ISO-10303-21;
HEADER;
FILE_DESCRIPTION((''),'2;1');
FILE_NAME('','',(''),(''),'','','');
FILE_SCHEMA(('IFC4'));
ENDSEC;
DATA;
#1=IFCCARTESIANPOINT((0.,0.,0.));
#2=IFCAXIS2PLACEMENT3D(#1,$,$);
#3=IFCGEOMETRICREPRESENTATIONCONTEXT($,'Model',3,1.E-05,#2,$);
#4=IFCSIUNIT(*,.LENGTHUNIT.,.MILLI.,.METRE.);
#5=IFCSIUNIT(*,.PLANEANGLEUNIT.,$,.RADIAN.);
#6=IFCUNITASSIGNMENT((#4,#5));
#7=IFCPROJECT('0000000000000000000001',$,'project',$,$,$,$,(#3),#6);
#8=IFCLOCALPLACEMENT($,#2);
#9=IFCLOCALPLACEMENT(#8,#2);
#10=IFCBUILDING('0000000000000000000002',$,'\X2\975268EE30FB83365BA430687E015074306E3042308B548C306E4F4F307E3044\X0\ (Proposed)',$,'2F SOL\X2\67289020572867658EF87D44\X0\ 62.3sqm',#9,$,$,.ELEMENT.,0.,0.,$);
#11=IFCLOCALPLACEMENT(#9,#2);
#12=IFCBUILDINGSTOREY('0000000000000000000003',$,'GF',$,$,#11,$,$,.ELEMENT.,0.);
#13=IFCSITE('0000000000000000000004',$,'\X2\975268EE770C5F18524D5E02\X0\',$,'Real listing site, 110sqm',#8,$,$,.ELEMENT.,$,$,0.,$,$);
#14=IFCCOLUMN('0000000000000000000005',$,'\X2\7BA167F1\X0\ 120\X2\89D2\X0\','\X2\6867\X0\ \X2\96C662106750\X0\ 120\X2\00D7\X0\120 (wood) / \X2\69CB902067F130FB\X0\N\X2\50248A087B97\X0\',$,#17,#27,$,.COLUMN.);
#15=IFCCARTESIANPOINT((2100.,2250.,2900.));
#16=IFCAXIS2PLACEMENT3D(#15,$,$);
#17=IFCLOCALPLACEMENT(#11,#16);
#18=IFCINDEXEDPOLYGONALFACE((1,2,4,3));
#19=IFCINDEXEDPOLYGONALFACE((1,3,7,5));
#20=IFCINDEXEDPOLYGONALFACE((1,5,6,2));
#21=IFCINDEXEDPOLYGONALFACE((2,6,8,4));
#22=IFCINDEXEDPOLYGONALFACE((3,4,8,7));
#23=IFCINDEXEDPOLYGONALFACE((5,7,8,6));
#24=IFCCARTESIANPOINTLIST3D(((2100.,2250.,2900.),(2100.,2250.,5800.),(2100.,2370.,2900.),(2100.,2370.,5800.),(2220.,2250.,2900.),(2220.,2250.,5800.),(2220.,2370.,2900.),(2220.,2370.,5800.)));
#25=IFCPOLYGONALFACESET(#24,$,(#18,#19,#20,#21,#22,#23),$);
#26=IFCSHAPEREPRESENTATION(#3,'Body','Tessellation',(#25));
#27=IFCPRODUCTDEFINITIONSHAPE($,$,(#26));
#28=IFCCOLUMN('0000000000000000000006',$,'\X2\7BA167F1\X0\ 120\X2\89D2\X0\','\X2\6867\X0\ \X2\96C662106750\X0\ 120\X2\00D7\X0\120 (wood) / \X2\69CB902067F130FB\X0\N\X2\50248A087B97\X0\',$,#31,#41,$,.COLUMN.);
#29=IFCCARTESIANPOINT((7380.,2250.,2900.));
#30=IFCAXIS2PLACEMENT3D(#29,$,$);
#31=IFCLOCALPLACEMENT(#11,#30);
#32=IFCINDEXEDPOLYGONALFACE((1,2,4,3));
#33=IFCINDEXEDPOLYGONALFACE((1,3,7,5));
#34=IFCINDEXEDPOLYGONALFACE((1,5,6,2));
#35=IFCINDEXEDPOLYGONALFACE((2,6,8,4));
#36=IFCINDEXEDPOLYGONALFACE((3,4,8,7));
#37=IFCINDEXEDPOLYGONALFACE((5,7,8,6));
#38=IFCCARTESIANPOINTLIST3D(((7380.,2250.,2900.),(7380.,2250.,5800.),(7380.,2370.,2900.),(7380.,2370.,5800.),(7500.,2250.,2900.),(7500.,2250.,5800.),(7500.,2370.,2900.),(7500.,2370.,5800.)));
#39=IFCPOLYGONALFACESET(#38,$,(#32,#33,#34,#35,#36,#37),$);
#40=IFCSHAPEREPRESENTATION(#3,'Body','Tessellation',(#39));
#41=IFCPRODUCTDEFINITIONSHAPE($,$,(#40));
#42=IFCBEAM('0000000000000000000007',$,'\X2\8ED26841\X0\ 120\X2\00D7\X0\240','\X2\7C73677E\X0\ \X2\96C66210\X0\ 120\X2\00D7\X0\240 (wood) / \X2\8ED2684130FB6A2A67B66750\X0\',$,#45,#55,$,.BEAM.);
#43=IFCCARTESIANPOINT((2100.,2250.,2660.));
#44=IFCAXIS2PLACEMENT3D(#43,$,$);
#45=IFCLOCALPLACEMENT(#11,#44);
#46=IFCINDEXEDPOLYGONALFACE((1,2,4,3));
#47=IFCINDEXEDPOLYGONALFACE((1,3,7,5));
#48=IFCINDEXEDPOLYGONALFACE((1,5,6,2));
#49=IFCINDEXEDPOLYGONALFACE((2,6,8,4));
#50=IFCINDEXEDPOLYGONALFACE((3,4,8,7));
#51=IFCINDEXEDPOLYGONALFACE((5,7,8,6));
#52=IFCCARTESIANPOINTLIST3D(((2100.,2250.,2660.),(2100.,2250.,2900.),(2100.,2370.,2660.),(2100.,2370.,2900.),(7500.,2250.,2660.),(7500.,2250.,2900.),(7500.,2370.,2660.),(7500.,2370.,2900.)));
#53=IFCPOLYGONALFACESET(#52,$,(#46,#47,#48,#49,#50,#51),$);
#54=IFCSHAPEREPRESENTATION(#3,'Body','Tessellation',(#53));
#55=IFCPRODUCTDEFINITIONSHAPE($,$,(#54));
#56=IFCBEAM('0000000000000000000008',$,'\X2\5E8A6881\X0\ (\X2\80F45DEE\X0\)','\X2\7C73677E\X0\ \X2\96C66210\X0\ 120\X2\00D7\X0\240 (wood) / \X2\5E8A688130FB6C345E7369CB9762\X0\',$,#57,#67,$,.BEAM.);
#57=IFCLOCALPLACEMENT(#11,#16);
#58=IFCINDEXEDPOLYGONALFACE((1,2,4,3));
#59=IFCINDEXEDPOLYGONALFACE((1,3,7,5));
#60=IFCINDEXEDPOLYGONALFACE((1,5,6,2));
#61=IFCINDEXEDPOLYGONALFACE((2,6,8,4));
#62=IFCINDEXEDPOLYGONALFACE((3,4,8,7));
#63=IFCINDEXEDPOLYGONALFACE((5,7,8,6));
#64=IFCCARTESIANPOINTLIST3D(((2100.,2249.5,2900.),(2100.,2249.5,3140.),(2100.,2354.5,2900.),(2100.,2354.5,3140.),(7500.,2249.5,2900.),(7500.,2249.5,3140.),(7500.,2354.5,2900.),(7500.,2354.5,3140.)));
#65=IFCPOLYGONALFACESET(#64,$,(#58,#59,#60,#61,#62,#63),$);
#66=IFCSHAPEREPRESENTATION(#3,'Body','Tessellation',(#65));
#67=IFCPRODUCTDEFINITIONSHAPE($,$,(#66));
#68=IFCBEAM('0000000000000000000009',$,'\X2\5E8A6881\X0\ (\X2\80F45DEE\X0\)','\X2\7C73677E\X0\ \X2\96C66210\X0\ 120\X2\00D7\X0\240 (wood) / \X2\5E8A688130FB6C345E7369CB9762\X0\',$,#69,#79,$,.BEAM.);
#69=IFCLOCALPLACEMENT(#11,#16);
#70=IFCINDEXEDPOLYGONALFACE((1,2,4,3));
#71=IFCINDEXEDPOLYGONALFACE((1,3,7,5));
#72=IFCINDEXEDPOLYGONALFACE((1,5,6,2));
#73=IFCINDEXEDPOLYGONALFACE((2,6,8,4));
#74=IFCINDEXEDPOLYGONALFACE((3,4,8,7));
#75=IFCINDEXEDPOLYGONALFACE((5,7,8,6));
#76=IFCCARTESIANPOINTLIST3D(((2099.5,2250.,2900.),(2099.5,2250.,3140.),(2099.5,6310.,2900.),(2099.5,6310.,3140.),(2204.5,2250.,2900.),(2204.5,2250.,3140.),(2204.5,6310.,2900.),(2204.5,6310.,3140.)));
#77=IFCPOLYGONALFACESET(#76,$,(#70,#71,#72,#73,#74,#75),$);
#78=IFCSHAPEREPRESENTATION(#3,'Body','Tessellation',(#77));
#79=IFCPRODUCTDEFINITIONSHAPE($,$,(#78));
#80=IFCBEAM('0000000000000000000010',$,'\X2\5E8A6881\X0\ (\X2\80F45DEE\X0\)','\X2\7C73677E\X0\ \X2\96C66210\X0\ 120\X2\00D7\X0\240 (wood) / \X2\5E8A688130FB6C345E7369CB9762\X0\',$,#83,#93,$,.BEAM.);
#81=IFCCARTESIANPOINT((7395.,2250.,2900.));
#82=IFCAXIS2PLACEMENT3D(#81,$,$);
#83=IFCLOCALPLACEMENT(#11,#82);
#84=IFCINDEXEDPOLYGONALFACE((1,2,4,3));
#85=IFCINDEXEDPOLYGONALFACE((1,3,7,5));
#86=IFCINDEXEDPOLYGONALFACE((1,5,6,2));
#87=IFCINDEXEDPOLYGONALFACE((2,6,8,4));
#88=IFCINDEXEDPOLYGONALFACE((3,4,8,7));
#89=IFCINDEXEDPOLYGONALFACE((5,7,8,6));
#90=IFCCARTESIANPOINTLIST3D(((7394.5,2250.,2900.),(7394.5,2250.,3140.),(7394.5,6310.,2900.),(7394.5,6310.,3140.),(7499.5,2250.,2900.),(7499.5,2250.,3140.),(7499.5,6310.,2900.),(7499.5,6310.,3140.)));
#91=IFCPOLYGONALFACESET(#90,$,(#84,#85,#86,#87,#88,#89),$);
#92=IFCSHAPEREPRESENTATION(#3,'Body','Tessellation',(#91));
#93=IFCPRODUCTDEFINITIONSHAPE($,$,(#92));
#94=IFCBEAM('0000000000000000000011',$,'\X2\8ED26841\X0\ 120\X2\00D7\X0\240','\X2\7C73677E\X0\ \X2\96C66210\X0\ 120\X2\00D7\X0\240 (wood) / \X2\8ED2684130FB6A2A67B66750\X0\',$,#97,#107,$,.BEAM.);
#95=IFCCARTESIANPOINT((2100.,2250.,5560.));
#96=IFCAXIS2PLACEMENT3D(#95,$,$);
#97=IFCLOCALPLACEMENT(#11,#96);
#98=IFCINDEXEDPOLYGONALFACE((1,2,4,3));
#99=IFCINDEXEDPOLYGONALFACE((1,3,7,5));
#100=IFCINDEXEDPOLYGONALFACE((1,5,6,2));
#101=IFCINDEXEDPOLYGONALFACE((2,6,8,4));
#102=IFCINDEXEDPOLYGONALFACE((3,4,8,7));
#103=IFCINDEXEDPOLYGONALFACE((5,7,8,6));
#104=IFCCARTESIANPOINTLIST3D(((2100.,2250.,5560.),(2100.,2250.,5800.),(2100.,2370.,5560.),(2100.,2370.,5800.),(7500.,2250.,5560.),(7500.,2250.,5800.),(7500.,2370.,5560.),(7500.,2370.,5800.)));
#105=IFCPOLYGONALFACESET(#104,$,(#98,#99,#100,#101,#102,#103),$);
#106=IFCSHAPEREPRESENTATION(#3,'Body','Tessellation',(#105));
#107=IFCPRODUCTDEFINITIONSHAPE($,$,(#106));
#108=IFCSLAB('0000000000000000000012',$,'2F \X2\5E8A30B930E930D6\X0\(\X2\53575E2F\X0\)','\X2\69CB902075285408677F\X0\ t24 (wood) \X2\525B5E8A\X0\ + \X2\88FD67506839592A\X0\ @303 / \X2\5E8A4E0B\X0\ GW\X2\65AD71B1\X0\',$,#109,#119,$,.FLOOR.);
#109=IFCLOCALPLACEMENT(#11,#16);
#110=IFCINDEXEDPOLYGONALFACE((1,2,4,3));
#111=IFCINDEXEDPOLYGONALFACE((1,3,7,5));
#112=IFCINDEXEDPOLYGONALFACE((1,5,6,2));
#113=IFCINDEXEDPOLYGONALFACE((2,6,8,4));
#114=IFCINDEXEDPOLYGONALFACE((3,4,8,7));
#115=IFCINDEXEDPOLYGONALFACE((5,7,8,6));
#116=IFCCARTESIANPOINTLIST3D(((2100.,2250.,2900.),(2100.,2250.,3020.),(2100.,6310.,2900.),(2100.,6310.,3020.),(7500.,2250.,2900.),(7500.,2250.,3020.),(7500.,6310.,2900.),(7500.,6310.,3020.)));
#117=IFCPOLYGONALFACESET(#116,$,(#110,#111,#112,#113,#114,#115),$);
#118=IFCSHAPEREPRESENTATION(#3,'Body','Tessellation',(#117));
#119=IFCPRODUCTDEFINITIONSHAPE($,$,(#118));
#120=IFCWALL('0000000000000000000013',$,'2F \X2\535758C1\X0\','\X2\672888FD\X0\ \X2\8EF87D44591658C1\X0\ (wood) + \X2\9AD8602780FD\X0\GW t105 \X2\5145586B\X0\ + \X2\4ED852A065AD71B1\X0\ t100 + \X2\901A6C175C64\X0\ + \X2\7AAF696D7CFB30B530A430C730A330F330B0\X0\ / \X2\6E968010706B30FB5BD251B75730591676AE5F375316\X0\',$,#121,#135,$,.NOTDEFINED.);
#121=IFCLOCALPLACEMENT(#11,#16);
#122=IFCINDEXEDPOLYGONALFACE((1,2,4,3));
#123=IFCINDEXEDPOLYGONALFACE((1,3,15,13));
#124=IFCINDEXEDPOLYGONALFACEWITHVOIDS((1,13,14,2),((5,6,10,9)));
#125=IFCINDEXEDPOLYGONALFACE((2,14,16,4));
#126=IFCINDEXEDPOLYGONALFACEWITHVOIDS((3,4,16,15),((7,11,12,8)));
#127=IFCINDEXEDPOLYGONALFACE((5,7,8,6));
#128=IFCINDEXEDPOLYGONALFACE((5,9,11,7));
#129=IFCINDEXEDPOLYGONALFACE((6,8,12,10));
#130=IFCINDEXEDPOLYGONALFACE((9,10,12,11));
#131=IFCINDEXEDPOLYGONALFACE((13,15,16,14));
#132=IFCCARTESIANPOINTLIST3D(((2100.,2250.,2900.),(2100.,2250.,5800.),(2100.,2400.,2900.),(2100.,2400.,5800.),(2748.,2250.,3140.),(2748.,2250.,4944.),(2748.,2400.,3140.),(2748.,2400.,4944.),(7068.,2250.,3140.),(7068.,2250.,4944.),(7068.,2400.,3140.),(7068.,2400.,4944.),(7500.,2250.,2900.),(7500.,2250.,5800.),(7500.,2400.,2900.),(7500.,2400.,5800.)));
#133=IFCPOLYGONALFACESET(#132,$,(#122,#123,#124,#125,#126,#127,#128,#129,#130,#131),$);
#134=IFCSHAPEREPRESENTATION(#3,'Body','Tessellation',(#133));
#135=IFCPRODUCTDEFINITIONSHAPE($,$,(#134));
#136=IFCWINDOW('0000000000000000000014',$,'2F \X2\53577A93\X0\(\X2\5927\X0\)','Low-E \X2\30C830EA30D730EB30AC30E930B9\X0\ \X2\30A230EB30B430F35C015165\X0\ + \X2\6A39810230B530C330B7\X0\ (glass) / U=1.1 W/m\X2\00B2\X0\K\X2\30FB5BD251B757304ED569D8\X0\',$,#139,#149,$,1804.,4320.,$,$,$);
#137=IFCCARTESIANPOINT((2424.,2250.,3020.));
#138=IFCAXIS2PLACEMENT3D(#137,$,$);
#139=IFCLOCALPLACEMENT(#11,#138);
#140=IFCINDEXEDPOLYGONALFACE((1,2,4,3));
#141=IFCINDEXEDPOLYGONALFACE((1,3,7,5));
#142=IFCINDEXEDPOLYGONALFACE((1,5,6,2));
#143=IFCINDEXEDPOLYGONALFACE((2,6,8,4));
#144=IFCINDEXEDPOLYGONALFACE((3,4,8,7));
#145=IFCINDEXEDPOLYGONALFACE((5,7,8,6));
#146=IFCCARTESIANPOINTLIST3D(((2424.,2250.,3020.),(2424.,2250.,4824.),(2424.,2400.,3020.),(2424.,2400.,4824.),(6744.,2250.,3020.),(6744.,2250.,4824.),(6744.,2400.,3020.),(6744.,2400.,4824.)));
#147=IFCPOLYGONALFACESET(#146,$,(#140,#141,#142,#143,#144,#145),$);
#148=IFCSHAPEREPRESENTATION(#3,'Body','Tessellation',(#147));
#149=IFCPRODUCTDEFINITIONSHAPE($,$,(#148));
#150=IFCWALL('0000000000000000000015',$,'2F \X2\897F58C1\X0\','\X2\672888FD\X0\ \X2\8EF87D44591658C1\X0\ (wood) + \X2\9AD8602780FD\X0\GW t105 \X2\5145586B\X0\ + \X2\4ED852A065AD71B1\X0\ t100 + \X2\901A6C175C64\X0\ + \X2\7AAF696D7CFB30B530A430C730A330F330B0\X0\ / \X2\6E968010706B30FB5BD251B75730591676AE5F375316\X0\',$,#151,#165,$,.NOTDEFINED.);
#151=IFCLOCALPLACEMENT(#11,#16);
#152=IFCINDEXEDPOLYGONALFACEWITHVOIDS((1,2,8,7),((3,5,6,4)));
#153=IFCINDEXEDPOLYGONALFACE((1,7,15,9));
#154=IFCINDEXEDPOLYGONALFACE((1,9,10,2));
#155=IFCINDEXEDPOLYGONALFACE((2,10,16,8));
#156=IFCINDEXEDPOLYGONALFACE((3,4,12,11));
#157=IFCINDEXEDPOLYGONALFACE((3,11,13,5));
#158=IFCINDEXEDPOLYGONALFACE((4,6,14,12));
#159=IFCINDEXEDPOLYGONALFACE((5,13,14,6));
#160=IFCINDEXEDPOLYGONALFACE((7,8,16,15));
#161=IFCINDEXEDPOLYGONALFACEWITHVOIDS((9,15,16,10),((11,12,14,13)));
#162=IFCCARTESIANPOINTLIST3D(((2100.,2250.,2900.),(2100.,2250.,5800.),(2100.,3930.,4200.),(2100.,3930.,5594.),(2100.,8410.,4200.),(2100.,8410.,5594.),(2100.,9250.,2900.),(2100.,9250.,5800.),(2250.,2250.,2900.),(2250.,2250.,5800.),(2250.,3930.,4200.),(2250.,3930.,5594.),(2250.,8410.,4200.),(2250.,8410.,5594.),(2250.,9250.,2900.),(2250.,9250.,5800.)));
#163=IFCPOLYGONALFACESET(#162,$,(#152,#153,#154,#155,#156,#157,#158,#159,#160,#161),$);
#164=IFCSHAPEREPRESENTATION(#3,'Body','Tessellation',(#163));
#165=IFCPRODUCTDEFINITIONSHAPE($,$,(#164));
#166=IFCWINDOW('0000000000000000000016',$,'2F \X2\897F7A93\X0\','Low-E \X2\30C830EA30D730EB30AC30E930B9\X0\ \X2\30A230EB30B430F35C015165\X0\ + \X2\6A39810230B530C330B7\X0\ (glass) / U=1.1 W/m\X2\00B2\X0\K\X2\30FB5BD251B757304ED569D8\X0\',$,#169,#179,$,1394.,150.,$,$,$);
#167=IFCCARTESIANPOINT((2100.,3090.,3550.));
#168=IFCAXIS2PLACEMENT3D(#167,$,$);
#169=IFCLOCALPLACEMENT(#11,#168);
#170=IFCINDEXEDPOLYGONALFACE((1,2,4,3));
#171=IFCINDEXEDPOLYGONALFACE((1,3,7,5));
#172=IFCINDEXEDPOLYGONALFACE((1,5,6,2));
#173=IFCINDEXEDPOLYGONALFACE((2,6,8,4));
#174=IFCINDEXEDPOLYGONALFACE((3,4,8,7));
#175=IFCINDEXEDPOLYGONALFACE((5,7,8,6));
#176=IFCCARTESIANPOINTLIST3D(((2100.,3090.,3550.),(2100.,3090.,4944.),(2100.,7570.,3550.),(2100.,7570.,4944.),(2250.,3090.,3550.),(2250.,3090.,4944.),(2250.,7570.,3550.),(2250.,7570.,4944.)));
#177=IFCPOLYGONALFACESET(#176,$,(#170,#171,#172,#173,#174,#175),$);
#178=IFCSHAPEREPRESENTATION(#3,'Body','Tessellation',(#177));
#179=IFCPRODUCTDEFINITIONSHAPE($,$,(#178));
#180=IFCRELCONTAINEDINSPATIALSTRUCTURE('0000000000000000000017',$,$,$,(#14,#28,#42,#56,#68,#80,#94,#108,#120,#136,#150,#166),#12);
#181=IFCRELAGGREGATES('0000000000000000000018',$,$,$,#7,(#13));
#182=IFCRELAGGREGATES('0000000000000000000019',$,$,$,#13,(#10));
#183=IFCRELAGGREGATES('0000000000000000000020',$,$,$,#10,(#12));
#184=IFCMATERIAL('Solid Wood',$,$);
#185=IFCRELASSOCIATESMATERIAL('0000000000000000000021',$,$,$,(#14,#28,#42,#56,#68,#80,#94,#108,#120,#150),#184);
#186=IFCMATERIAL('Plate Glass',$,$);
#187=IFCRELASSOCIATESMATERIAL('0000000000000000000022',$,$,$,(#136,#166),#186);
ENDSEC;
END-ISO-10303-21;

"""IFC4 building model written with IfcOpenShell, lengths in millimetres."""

from ifc_helpers import new_model, si_unit, frame, frame_2d, origin, place, context, project, spatial, rectangle, extrude, material, element, fill, save


model = new_model("IFC4")

# Units and contexts
model_context = context("Model", 3, precision=1e-05, world=origin())
ifc_project = project(units=[si_unit("LENGTHUNIT", "METRE", prefix="MILLI"), si_unit("PLANEANGLEUNIT", "RADIAN")], contexts=[model_context])

# Site, building, storey
site_placement = place(None, origin())
site = spatial("IfcSite", under=ifc_project, at=site_placement, Name="青森県弘前市", ObjectType="Real listing site, 110sqm", CompositionType="ELEMENT", RefElevation=0.0)
building_placement = place(site_placement, origin())
building = spatial("IfcBuilding", under=site, at=building_placement, Name="青森・茶室と縁側のある和の住まい (Proposed)", ObjectType="2F SOL木造在来軸組 62.3sqm", CompositionType="ELEMENT", ElevationOfRefHeight=0.0, ElevationOfTerrain=0.0)
storey_placement = place(building_placement, origin())
storey = spatial("IfcBuildingStorey", under=building, at=storey_placement, Name="GF", CompositionType="ELEMENT", Elevation=0.0)

# Columns
ifc_material_1 = material(Name="Solid Wood")
column_1_placement = place(storey_placement, frame((2100.0, 2250.0, 2900.0)))
element("IfcColumn", 1, at=column_1_placement, inside=storey, material=ifc_material_1, Name="管柱 120角", Description="桧 集成材 120×120 (wood) / 構造柱・N値計算", PredefinedType="COLUMN", context=model_context, shape_type="SweptSolid", body=[
    extrude(rectangle(XDim=120.0, YDim=120.0, at=frame_2d((60.0, 60.0))), frame((2100.0, 2250.0, 2900.0)), (0.0, 0.0, 1.0), 2900.0),
])
column_2_placement = place(storey_placement, frame((7380.0, 2250.0, 2900.0)))
element("IfcColumn", 2, at=column_2_placement, inside=storey, material=ifc_material_1, Name="管柱 120角", Description="桧 集成材 120×120 (wood) / 構造柱・N値計算", PredefinedType="COLUMN", context=model_context, shape_type="SweptSolid", body=[
    extrude(rectangle(XDim=120.0, YDim=120.0, at=frame_2d((60.0, 60.0))), frame((7380.0, 2250.0, 2900.0)), (0.0, 0.0, 1.0), 2900.0),
])

# Beams
beam_1_placement = place(storey_placement, frame((2100.0, 2250.0, 2660.0)))
element("IfcBeam", 3, at=beam_1_placement, inside=storey, material=ifc_material_1, Name="軒桁 120×240", Description="米松 集成 120×240 (wood) / 軒桁・横架材", PredefinedType="BEAM", context=model_context, shape_type="SweptSolid", body=[
    extrude(rectangle(XDim=5400.0, YDim=120.0, at=frame_2d((2700.0, 60.0))), frame((2100.0, 2250.0, 2660.0)), (0.0, 0.0, 1.0), 240.0),
])
beam_2_placement = place(storey_placement, frame((2100.0, 2250.0, 2900.0)))
element("IfcBeam", 4, at=beam_2_placement, inside=storey, material=ifc_material_1, Name="床梁 (胴差)", Description="米松 集成 120×240 (wood) / 床梁・水平構面", PredefinedType="BEAM", context=model_context, shape_type="SweptSolid", body=[
    extrude(rectangle(XDim=5400.0, YDim=105.0, at=frame_2d((2700.0, 52.0))), frame((2100.0, 2250.0, 2900.0)), (0.0, 0.0, 1.0), 240.0),
])
beam_3_placement = place(storey_placement, frame((2100.0, 2250.0, 2900.0)))
element("IfcBeam", 5, at=beam_3_placement, inside=storey, material=ifc_material_1, Name="床梁 (胴差)", Description="米松 集成 120×240 (wood) / 床梁・水平構面", PredefinedType="BEAM", context=model_context, shape_type="SweptSolid", body=[
    extrude(rectangle(XDim=105.0, YDim=4060.0, at=frame_2d((52.0, 2030.0))), frame((2100.0, 2250.0, 2900.0)), (0.0, 0.0, 1.0), 240.0),
])
beam_4_placement = place(storey_placement, frame((7395.0, 2250.0, 2900.0)))
element("IfcBeam", 6, at=beam_4_placement, inside=storey, material=ifc_material_1, Name="床梁 (胴差)", Description="米松 集成 120×240 (wood) / 床梁・水平構面", PredefinedType="BEAM", context=model_context, shape_type="SweptSolid", body=[
    extrude(rectangle(XDim=105.0, YDim=4060.0, at=frame_2d((52.0, 2030.0))), frame((7395.0, 2250.0, 2900.0)), (0.0, 0.0, 1.0), 240.0),
])
beam_5_placement = place(storey_placement, frame((2100.0, 2250.0, 5560.0)))
element("IfcBeam", 7, at=beam_5_placement, inside=storey, material=ifc_material_1, Name="軒桁 120×240", Description="米松 集成 120×240 (wood) / 軒桁・横架材", PredefinedType="BEAM", context=model_context, shape_type="SweptSolid", body=[
    extrude(rectangle(XDim=5400.0, YDim=120.0, at=frame_2d((2700.0, 60.0))), frame((2100.0, 2250.0, 5560.0)), (0.0, 0.0, 1.0), 240.0),
])

# Slab
slab_placement = place(storey_placement, frame((2100.0, 2250.0, 2900.0)))
element("IfcSlab", 8, at=slab_placement, inside=storey, material=ifc_material_1, Name="2F 床スラブ(南帯)", Description="構造用合板 t24 (wood) 剛床 + 製材根太 @303 / 床下 GW断熱", PredefinedType="FLOOR", context=model_context, shape_type="SweptSolid", body=[
    extrude(rectangle(XDim=5400.0, YDim=4060.0, at=frame_2d((2700.0, 2030.0))), frame((2100.0, 2250.0, 2900.0)), (0.0, 0.0, 1.0), 120.0),
])

# Walls, openings, windows
wall_1_placement = place(storey_placement, frame((2100.0, 2250.0, 2900.0)))
wall_1 = element("IfcWall", 9, at=wall_1_placement, inside=storey, material=ifc_material_1, Name="2F 南壁", Description="木製 軸組外壁 (wood) + 高性能GW t105 充填 + 付加断熱 t100 + 通気層 + 窯業系サイディング / 準耐火・寒冷地外皮強化", PredefinedType="NOTDEFINED", context=model_context, shape_type="SweptSolid", body=[
    extrude(rectangle(XDim=5400.0, YDim=150.0, at=frame_2d((2700.0, 75.0))), frame((2100.0, 2250.0, 2900.0)), (0.0, 0.0, 1.0), 2900.0),
])
opening_1_placement = place(storey_placement, frame((2424.0, 2250.0, 3020.0)))
opening_1 = element("IfcOpeningElement", 10, at=opening_1_placement, cuts=wall_1, PredefinedType="NOTDEFINED", context=model_context, shape_type="SweptSolid", body=[
    extrude(rectangle(XDim=4320.0, YDim=150.0, at=frame_2d((2160.0, 75.0))), frame((2424.0, 2250.0, 3020.0)), (0.0, 0.0, 1.0), 1804.0),
])
ifc_material_2 = material(Name="Plate Glass")
window_1_placement = place(storey_placement, frame((2424.0, 2250.0, 3020.0)))
window_1 = element("IfcWindow", 11, at=window_1_placement, inside=storey, material=ifc_material_2, Name="2F 南窓(大)", Description="Low-E トリプルガラス アルゴン封入 + 樹脂サッシ (glass) / U=1.1 W/m²K・寒冷地仕様", OverallHeight=1804.0, OverallWidth=4320.0, context=model_context, shape_type="SweptSolid", body=[
    extrude(rectangle(XDim=4320.0, YDim=150.0, at=frame_2d((2160.0, 75.0))), frame((2424.0, 2250.0, 3020.0)), (0.0, 0.0, 1.0), 1804.0),
])
fill(opening_1, window_1)
wall_2_placement = place(storey_placement, frame((2100.0, 2250.0, 2900.0)))
wall_2 = element("IfcWall", 12, at=wall_2_placement, inside=storey, material=ifc_material_1, Name="2F 西壁", Description="木製 軸組外壁 (wood) + 高性能GW t105 充填 + 付加断熱 t100 + 通気層 + 窯業系サイディング / 準耐火・寒冷地外皮強化", PredefinedType="NOTDEFINED", context=model_context, shape_type="SweptSolid", body=[
    extrude(rectangle(XDim=150.0, YDim=7000.0, at=frame_2d((75.0, 3500.0))), frame((2100.0, 2250.0, 2900.0)), (0.0, 0.0, 1.0), 2900.0),
])
opening_2_placement = place(storey_placement, frame((2100.0, 3090.0, 3550.0)))
opening_2 = element("IfcOpeningElement", 13, at=opening_2_placement, cuts=wall_2, PredefinedType="NOTDEFINED", context=model_context, shape_type="SweptSolid", body=[
    extrude(rectangle(XDim=150.0, YDim=4480.0, at=frame_2d((75.0, 2240.0))), frame((2100.0, 3090.0, 3550.0)), (0.0, 0.0, 1.0), 1394.0),
])
window_2_placement = place(storey_placement, frame((2100.0, 3090.0, 3550.0)))
window_2 = element("IfcWindow", 14, at=window_2_placement, inside=storey, material=ifc_material_2, Name="2F 西窓", Description="Low-E トリプルガラス アルゴン封入 + 樹脂サッシ (glass) / U=1.1 W/m²K・寒冷地仕様", OverallHeight=1394.0, OverallWidth=150.0, context=model_context, shape_type="SweptSolid", body=[
    extrude(rectangle(XDim=150.0, YDim=4480.0, at=frame_2d((75.0, 2240.0))), frame((2100.0, 3090.0, 3550.0)), (0.0, 0.0, 1.0), 1394.0),
])
fill(opening_2, window_2)

save(model, "model.ifc")
